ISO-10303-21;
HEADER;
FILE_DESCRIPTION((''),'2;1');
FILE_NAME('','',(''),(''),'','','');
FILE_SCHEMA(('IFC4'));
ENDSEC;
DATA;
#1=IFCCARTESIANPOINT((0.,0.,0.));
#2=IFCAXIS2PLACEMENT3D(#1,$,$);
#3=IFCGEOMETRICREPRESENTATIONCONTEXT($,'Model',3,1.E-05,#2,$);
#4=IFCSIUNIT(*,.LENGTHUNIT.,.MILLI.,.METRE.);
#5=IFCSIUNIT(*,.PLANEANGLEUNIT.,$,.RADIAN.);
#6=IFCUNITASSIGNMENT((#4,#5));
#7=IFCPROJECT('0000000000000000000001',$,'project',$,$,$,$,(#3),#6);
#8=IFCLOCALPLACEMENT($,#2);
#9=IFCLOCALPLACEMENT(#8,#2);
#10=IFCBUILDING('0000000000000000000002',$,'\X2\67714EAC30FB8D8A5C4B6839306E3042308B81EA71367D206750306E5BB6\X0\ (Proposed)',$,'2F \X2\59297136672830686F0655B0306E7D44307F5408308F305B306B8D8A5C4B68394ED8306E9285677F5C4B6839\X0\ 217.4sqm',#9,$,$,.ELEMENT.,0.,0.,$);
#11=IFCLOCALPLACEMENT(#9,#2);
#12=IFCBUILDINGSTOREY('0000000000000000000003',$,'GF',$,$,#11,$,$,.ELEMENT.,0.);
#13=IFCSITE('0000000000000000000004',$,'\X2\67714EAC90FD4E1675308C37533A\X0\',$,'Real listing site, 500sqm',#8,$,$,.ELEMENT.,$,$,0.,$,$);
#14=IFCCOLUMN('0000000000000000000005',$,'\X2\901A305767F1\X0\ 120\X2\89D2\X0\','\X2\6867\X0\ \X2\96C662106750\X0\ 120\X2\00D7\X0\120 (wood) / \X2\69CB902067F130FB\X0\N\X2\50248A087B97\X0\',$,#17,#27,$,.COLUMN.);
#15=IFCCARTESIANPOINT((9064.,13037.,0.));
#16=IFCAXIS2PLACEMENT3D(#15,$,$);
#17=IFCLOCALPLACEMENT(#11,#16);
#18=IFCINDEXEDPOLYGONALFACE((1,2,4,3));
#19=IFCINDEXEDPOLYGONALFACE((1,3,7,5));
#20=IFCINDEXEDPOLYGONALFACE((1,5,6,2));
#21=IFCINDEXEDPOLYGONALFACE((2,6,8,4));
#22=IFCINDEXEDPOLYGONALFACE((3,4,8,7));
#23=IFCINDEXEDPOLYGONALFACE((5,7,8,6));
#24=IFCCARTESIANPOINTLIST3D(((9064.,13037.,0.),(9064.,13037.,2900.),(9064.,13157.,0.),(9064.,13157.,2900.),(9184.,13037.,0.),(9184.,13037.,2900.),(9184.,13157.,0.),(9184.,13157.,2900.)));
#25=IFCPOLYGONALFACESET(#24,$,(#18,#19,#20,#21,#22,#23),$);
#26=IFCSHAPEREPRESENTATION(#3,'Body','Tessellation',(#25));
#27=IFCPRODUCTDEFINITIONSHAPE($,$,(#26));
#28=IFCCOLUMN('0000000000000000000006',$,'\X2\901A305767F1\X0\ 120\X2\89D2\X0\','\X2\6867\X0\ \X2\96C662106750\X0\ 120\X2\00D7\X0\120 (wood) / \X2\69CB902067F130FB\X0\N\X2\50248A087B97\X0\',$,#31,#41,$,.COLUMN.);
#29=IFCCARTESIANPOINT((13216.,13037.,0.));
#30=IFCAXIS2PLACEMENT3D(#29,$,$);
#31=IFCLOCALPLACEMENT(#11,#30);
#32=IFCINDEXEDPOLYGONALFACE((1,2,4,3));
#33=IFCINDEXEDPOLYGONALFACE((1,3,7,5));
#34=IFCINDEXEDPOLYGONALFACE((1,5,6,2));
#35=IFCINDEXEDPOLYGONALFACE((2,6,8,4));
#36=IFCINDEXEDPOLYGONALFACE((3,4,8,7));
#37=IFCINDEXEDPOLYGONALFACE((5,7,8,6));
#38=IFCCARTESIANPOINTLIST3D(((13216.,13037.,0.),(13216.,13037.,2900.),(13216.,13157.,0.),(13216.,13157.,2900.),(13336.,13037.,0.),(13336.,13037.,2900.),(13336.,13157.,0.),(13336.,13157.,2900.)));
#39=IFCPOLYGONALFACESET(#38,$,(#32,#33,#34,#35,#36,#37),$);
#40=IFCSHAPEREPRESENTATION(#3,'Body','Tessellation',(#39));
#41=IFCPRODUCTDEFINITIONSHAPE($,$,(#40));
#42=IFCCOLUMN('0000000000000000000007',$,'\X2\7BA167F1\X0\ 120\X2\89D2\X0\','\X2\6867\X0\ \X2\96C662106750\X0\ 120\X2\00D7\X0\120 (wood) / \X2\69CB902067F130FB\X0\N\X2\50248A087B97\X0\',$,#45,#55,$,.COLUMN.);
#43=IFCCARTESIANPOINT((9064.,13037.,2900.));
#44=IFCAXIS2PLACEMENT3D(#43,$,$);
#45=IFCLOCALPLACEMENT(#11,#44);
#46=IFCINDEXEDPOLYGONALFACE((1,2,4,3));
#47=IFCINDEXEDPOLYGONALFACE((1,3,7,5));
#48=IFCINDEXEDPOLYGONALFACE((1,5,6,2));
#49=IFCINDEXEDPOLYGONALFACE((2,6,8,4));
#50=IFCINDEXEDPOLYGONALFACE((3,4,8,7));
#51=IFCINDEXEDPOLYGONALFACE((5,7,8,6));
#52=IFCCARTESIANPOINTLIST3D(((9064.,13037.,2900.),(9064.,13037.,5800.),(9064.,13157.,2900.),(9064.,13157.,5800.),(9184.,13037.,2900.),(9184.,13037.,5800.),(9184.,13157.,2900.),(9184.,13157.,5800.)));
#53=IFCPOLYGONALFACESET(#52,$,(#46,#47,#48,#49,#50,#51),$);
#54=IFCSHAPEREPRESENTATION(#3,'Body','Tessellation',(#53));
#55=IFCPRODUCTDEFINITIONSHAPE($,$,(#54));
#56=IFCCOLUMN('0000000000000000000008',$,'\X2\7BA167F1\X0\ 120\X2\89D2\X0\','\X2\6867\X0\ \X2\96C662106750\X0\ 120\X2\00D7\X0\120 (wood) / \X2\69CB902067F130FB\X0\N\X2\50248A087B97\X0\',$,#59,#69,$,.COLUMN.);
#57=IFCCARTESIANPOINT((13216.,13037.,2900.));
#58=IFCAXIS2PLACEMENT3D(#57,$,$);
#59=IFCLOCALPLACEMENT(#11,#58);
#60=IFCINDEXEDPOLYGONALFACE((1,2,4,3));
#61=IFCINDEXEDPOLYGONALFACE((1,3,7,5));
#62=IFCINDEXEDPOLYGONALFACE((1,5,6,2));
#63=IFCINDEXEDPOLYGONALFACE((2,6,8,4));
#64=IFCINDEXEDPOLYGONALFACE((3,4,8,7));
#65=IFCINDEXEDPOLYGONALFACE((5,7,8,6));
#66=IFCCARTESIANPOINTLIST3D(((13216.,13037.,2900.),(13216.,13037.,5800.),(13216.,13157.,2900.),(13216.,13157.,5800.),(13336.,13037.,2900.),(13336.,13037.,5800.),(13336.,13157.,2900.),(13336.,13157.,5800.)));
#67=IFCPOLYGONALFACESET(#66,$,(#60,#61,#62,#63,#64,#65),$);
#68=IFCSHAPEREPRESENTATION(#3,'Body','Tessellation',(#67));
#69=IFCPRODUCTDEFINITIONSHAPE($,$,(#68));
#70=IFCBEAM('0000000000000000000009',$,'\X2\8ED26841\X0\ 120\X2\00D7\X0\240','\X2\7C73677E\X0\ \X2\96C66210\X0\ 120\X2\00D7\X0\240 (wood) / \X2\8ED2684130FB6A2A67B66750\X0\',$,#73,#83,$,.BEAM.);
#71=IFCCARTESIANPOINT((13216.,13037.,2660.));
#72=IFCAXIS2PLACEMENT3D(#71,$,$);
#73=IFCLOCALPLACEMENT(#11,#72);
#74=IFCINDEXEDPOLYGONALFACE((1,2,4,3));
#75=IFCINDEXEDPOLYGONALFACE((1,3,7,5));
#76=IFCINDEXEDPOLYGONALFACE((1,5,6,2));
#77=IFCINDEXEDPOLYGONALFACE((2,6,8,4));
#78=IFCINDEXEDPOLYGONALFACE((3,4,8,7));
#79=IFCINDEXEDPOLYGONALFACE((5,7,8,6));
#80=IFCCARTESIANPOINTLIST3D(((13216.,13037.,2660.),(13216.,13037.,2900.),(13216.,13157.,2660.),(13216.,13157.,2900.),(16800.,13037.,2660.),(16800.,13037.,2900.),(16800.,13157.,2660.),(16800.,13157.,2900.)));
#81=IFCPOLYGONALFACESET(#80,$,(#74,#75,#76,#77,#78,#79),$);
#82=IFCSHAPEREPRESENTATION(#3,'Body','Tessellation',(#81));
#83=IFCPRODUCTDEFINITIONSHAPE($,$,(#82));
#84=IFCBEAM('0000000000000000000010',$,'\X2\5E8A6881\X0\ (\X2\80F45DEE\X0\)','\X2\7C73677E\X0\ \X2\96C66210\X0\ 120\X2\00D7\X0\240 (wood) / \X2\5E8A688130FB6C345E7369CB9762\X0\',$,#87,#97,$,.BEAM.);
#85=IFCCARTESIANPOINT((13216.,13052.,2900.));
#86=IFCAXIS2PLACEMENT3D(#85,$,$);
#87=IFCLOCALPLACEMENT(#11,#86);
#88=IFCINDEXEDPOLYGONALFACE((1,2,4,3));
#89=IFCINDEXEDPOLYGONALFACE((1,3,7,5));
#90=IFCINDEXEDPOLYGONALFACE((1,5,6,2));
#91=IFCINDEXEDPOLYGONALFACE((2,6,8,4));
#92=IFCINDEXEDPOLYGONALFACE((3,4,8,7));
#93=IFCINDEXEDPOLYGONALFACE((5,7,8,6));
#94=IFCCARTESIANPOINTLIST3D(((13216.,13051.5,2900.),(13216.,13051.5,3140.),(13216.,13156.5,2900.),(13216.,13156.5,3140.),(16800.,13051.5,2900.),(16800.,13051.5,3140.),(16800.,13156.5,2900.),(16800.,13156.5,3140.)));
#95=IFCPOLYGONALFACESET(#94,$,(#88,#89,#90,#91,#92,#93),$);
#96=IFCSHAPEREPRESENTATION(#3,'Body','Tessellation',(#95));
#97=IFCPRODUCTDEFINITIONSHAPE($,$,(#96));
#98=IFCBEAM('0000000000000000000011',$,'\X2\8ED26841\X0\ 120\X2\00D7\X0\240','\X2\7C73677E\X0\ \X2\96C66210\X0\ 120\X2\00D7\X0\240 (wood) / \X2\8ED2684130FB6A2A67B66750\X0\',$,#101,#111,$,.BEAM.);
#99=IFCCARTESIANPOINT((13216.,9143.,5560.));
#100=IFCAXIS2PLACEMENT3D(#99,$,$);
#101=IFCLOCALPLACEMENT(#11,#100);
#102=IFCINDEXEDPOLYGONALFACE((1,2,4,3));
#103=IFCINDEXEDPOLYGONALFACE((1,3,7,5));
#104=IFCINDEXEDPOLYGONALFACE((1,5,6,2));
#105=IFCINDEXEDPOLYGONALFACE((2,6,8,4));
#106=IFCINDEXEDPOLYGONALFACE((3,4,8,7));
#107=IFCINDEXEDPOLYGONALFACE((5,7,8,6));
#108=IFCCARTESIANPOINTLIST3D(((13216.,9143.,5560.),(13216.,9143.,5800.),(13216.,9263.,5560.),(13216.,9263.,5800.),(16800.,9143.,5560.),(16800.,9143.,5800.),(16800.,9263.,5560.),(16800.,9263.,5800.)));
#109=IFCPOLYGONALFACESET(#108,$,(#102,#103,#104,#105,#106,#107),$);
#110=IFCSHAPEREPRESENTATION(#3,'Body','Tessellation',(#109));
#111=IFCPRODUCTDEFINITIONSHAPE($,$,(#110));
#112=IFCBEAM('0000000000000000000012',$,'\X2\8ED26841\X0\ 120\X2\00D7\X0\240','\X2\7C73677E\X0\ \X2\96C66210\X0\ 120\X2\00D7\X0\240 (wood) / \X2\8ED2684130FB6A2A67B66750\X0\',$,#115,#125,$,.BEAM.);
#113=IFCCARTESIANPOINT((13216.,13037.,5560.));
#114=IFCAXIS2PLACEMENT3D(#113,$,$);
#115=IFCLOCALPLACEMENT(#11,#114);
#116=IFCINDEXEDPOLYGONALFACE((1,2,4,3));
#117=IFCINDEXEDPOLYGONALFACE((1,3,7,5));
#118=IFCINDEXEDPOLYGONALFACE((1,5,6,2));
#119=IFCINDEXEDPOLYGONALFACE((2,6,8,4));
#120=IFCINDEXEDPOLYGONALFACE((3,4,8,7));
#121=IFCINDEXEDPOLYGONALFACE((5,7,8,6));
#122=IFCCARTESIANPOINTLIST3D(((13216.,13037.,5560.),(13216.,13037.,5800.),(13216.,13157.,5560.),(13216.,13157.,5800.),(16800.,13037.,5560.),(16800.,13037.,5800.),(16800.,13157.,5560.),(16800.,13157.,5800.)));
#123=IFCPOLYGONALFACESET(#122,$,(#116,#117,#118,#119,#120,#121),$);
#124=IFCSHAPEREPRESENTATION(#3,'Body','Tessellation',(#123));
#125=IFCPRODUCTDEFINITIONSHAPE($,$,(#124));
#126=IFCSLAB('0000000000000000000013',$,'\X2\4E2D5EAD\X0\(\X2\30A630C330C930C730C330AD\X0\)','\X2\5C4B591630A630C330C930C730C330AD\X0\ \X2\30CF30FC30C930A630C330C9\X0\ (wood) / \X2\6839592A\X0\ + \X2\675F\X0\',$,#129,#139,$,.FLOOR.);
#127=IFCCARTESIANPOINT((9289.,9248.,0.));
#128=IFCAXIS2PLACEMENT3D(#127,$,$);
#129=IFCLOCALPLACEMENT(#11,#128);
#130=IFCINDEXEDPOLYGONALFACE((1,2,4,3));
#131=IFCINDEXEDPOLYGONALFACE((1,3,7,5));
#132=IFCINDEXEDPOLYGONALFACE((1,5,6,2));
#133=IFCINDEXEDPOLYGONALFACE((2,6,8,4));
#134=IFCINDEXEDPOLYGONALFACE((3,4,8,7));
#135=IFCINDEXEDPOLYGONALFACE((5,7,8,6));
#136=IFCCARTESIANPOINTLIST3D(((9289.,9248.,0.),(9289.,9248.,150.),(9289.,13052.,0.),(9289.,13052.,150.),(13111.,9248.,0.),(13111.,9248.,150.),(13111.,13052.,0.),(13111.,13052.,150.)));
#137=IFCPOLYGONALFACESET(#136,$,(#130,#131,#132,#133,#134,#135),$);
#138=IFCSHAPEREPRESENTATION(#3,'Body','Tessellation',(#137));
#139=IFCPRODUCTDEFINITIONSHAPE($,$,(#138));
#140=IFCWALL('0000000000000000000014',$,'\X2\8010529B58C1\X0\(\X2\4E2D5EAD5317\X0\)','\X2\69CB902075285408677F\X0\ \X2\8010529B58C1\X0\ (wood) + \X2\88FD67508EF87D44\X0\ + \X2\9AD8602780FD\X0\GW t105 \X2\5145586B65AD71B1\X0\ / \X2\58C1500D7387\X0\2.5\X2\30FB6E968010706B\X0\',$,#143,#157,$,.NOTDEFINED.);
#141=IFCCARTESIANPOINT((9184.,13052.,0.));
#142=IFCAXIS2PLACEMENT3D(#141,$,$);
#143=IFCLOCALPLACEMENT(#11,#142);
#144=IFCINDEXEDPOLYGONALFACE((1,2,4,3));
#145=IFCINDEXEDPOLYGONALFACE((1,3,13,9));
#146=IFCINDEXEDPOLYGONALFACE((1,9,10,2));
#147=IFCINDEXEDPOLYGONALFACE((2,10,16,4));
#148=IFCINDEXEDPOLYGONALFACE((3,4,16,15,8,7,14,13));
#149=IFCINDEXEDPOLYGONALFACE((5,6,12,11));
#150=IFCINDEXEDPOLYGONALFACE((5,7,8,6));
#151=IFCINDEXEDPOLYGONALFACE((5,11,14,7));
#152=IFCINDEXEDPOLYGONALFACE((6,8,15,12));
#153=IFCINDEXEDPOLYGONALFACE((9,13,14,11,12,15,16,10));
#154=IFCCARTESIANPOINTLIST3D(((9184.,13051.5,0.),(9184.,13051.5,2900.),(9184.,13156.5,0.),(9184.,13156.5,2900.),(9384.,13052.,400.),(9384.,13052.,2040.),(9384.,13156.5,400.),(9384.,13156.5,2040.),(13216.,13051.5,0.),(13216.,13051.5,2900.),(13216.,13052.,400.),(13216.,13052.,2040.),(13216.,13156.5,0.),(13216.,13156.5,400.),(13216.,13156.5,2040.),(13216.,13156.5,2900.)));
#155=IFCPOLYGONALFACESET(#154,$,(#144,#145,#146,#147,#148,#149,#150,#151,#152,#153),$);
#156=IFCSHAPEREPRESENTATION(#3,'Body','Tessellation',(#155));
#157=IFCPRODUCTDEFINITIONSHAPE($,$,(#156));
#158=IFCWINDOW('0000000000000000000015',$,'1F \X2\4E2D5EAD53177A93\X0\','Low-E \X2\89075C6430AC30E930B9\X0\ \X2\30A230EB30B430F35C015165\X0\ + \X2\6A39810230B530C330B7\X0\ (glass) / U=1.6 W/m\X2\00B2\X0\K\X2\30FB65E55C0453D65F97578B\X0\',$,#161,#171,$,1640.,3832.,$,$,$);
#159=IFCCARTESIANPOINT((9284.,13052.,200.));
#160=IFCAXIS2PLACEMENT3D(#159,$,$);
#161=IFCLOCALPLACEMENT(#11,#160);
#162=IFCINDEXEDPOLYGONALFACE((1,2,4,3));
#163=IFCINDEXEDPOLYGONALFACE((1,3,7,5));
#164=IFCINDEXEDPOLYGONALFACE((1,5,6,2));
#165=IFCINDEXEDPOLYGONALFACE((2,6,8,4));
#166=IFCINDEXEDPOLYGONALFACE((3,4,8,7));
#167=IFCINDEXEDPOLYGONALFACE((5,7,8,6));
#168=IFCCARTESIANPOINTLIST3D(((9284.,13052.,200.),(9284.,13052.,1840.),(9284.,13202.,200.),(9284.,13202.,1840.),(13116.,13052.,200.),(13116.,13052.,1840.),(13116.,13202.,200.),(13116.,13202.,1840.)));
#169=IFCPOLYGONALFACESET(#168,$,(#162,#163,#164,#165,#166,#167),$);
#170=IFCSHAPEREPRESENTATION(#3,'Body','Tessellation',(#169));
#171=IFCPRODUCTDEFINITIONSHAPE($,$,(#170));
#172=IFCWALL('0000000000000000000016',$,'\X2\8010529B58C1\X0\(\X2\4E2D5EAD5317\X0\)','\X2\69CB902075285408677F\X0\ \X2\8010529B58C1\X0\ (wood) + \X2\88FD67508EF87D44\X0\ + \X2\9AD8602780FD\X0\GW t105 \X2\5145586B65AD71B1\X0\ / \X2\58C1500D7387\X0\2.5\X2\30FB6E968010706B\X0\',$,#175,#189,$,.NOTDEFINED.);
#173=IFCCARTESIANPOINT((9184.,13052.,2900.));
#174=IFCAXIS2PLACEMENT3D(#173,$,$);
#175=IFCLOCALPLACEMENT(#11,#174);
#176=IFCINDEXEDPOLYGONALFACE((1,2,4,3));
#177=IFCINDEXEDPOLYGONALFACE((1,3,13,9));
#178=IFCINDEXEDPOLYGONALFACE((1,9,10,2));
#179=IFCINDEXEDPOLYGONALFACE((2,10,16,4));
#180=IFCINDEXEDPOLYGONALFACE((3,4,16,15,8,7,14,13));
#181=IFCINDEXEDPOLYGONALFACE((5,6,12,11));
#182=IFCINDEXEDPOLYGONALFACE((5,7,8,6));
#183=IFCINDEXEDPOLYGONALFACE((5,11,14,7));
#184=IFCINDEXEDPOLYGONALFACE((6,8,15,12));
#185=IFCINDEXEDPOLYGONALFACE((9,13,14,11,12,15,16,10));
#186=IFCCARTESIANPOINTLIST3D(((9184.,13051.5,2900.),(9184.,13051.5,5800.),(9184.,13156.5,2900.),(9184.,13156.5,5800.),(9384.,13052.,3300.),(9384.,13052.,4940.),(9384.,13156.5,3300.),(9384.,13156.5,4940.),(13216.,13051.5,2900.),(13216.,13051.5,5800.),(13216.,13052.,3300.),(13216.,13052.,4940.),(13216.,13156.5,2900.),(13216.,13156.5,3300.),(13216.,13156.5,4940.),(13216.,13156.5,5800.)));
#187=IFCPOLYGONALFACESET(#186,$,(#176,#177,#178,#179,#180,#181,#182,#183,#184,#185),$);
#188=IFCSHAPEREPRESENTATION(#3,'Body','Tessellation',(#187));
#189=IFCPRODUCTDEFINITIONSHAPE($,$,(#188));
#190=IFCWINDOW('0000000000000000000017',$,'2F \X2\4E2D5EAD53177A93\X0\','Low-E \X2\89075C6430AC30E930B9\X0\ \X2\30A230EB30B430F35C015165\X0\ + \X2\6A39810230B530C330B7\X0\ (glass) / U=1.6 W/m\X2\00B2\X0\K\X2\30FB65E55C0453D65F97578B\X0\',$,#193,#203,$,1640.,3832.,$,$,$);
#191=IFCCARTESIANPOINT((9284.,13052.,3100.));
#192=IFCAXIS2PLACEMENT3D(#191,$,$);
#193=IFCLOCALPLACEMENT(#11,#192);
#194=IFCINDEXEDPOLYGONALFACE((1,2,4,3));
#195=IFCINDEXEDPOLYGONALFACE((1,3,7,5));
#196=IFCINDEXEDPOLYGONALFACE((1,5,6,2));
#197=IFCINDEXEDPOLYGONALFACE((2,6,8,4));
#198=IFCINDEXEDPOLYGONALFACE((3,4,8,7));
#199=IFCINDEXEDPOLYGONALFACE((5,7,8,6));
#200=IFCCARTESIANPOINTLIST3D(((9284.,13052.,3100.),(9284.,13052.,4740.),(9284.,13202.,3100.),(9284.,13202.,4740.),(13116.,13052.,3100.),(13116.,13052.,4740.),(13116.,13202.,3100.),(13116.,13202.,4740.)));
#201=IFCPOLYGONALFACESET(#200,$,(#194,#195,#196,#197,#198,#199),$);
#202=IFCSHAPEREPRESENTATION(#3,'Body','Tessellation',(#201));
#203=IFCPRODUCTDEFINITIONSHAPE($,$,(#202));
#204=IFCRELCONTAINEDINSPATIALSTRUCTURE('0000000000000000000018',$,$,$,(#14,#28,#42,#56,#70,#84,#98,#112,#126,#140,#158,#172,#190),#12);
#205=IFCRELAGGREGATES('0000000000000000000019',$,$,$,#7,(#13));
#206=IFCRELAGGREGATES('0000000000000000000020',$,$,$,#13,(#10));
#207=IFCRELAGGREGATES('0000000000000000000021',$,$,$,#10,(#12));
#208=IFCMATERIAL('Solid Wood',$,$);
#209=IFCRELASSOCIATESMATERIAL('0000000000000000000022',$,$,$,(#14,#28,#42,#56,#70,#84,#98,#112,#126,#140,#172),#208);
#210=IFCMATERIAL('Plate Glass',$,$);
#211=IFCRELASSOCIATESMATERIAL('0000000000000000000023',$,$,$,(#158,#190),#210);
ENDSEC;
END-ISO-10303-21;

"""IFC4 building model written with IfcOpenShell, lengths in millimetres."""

from ifc_helpers import new_model, si_unit, frame, frame_2d, origin, place, context, project, spatial, rectangle, extrude, material, element, fill, save


model = new_model("IFC4")

# Units and contexts
model_context = context("Model", 3, precision=1e-05, world=origin())
ifc_project = project(units=[si_unit("LENGTHUNIT", "METRE", prefix="MILLI"), si_unit("PLANEANGLEUNIT", "RADIAN")], contexts=[model_context])

# Site, building, storey
site_placement = place(None, origin())
site = spatial("IfcSite", under=ifc_project, at=site_placement, Name="東京都世田谷区", ObjectType="Real listing site, 500sqm", CompositionType="ELEMENT", RefElevation=0.0)
building_placement = place(site_placement, origin())
building = spatial("IfcBuilding", under=site, at=building_placement, Name="東京・越屋根のある自然素材の家 (Proposed)", ObjectType="2F 天然木と漆喰の組み合わせに越屋根付の銅板屋根 217.4sqm", CompositionType="ELEMENT", ElevationOfRefHeight=0.0, ElevationOfTerrain=0.0)
storey_placement = place(building_placement, origin())
storey = spatial("IfcBuildingStorey", under=building, at=storey_placement, Name="GF", CompositionType="ELEMENT", Elevation=0.0)

# Columns
ifc_material_1 = material(Name="Solid Wood")
column_1_placement = place(storey_placement, frame((9064.0, 13037.0, 0.0)))
element("IfcColumn", 1, at=column_1_placement, inside=storey, material=ifc_material_1, Name="通し柱 120角", Description="桧 集成材 120×120 (wood) / 構造柱・N値計算", PredefinedType="COLUMN", context=model_context, shape_type="SweptSolid", body=[
    extrude(rectangle(XDim=120.0, YDim=120.0, at=frame_2d((60.0, 60.0))), frame((9064.0, 13037.0, 0.0)), (0.0, 0.0, 1.0), 2900.0),
])
column_2_placement = place(storey_placement, frame((13216.0, 13037.0, 0.0)))
element("IfcColumn", 2, at=column_2_placement, inside=storey, material=ifc_material_1, Name="通し柱 120角", Description="桧 集成材 120×120 (wood) / 構造柱・N値計算", PredefinedType="COLUMN", context=model_context, shape_type="SweptSolid", body=[
    extrude(rectangle(XDim=120.0, YDim=120.0, at=frame_2d((60.0, 60.0))), frame((13216.0, 13037.0, 0.0)), (0.0, 0.0, 1.0), 2900.0),
])
column_3_placement = place(storey_placement, frame((9064.0, 13037.0, 2900.0)))
element("IfcColumn", 3, at=column_3_placement, inside=storey, material=ifc_material_1, Name="管柱 120角", Description="桧 集成材 120×120 (wood) / 構造柱・N値計算", PredefinedType="COLUMN", context=model_context, shape_type="SweptSolid", body=[
    extrude(rectangle(XDim=120.0, YDim=120.0, at=frame_2d((60.0, 60.0))), frame((9064.0, 13037.0, 2900.0)), (0.0, 0.0, 1.0), 2900.0),
])
column_4_placement = place(storey_placement, frame((13216.0, 13037.0, 2900.0)))
element("IfcColumn", 4, at=column_4_placement, inside=storey, material=ifc_material_1, Name="管柱 120角", Description="桧 集成材 120×120 (wood) / 構造柱・N値計算", PredefinedType="COLUMN", context=model_context, shape_type="SweptSolid", body=[
    extrude(rectangle(XDim=120.0, YDim=120.0, at=frame_2d((60.0, 60.0))), frame((13216.0, 13037.0, 2900.0)), (0.0, 0.0, 1.0), 2900.0),
])

# Beams
beam_1_placement = place(storey_placement, frame((13216.0, 13037.0, 2660.0)))
element("IfcBeam", 5, at=beam_1_placement, inside=storey, material=ifc_material_1, Name="軒桁 120×240", Description="米松 集成 120×240 (wood) / 軒桁・横架材", PredefinedType="BEAM", context=model_context, shape_type="SweptSolid", body=[
    extrude(rectangle(XDim=3584.0, YDim=120.0, at=frame_2d((1792.0, 60.0))), frame((13216.0, 13037.0, 2660.0)), (0.0, 0.0, 1.0), 240.0),
])
beam_2_placement = place(storey_placement, frame((13216.0, 13052.0, 2900.0)))
element("IfcBeam", 6, at=beam_2_placement, inside=storey, material=ifc_material_1, Name="床梁 (胴差)", Description="米松 集成 120×240 (wood) / 床梁・水平構面", PredefinedType="BEAM", context=model_context, shape_type="SweptSolid", body=[
    extrude(rectangle(XDim=3584.0, YDim=105.0, at=frame_2d((1792.0, 52.0))), frame((13216.0, 13052.0, 2900.0)), (0.0, 0.0, 1.0), 240.0),
])
beam_3_placement = place(storey_placement, frame((13216.0, 9143.0, 5560.0)))
element("IfcBeam", 7, at=beam_3_placement, inside=storey, material=ifc_material_1, Name="軒桁 120×240", Description="米松 集成 120×240 (wood) / 軒桁・横架材", PredefinedType="BEAM", context=model_context, shape_type="SweptSolid", body=[
    extrude(rectangle(XDim=3584.0, YDim=120.0, at=frame_2d((1792.0, 60.0))), frame((13216.0, 9143.0, 5560.0)), (0.0, 0.0, 1.0), 240.0),
])
beam_4_placement = place(storey_placement, frame((13216.0, 13037.0, 5560.0)))
element("IfcBeam", 8, at=beam_4_placement, inside=storey, material=ifc_material_1, Name="軒桁 120×240", Description="米松 集成 120×240 (wood) / 軒桁・横架材", PredefinedType="BEAM", context=model_context, shape_type="SweptSolid", body=[
    extrude(rectangle(XDim=3584.0, YDim=120.0, at=frame_2d((1792.0, 60.0))), frame((13216.0, 13037.0, 5560.0)), (0.0, 0.0, 1.0), 240.0),
])

# Slab
slab_placement = place(storey_placement, frame((9289.0, 9248.0, 0.0)))
element("IfcSlab", 9, at=slab_placement, inside=storey, material=ifc_material_1, Name="中庭(ウッドデッキ)", Description="屋外ウッドデッキ ハードウッド (wood) / 根太 + 束", PredefinedType="FLOOR", context=model_context, shape_type="SweptSolid", body=[
    extrude(rectangle(XDim=3822.0, YDim=3804.0, at=frame_2d((1911.0, 1902.0))), frame((9289.0, 9248.0, 0.0)), (0.0, 0.0, 1.0), 150.0),
])

# Wall, opening, window
wall_1_placement = place(storey_placement, frame((9184.0, 13052.0, 0.0)))
wall_1 = element("IfcWall", 10, at=wall_1_placement, inside=storey, material=ifc_material_1, Name="耐力壁(中庭北)", Description="構造用合板 耐力壁 (wood) + 製材軸組 + 高性能GW t105 充填断熱 / 壁倍率2.5・準耐火", PredefinedType="NOTDEFINED", context=model_context, shape_type="SweptSolid", body=[
    extrude(rectangle(XDim=4032.0, YDim=105.0, at=frame_2d((2016.0, 52.0))), frame((9184.0, 13052.0, 0.0)), (0.0, 0.0, 1.0), 2900.0),
])
opening_1_placement = place(storey_placement, frame((9284.0, 13052.0, 200.0)))
opening_1 = element("IfcOpeningElement", 11, at=opening_1_placement, cuts=wall_1, PredefinedType="NOTDEFINED", context=model_context, shape_type="SweptSolid", body=[
    extrude(rectangle(XDim=3832.0, YDim=150.0, at=frame_2d((1916.0, 75.0))), frame((9284.0, 13052.0, 200.0)), (0.0, 0.0, 1.0), 1640.0),
])
ifc_material_2 = material(Name="Plate Glass")
window_1_placement = place(storey_placement, frame((9284.0, 13052.0, 200.0)))
window_1 = element("IfcWindow", 12, at=window_1_placement, inside=storey, material=ifc_material_2, Name="1F 中庭北窓", Description="Low-E 複層ガラス アルゴン封入 + 樹脂サッシ (glass) / U=1.6 W/m²K・日射取得型", OverallHeight=1640.0, OverallWidth=3832.0, context=model_context, shape_type="SweptSolid", body=[
    extrude(rectangle(XDim=3832.0, YDim=150.0, at=frame_2d((1916.0, 75.0))), frame((9284.0, 13052.0, 200.0)), (0.0, 0.0, 1.0), 1640.0),
])
fill(opening_1, window_1)

# Wall, opening, window
wall_2_placement = place(storey_placement, frame((9184.0, 13052.0, 2900.0)))
wall_2 = element("IfcWall", 13, at=wall_2_placement, inside=storey, material=ifc_material_1, Name="耐力壁(中庭北)", Description="構造用合板 耐力壁 (wood) + 製材軸組 + 高性能GW t105 充填断熱 / 壁倍率2.5・準耐火", PredefinedType="NOTDEFINED", context=model_context, shape_type="SweptSolid", body=[
    extrude(rectangle(XDim=4032.0, YDim=105.0, at=frame_2d((2016.0, 52.0))), frame((9184.0, 13052.0, 2900.0)), (0.0, 0.0, 1.0), 2900.0),
])
opening_2_placement = place(storey_placement, frame((9284.0, 13052.0, 3100.0)))
opening_2 = element("IfcOpeningElement", 14, at=opening_2_placement, cuts=wall_2, PredefinedType="NOTDEFINED", context=model_context, shape_type="SweptSolid", body=[
    extrude(rectangle(XDim=3832.0, YDim=150.0, at=frame_2d((1916.0, 75.0))), frame((9284.0, 13052.0, 3100.0)), (0.0, 0.0, 1.0), 1640.0),
])
window_2_placement = place(storey_placement, frame((9284.0, 13052.0, 3100.0)))
window_2 = element("IfcWindow", 15, at=window_2_placement, inside=storey, material=ifc_material_2, Name="2F 中庭北窓", Description="Low-E 複層ガラス アルゴン封入 + 樹脂サッシ (glass) / U=1.6 W/m²K・日射取得型", OverallHeight=1640.0, OverallWidth=3832.0, context=model_context, shape_type="SweptSolid", body=[
    extrude(rectangle(XDim=3832.0, YDim=150.0, at=frame_2d((1916.0, 75.0))), frame((9284.0, 13052.0, 3100.0)), (0.0, 0.0, 1.0), 1640.0),
])
fill(opening_2, window_2)

save(model, "model.ifc")
